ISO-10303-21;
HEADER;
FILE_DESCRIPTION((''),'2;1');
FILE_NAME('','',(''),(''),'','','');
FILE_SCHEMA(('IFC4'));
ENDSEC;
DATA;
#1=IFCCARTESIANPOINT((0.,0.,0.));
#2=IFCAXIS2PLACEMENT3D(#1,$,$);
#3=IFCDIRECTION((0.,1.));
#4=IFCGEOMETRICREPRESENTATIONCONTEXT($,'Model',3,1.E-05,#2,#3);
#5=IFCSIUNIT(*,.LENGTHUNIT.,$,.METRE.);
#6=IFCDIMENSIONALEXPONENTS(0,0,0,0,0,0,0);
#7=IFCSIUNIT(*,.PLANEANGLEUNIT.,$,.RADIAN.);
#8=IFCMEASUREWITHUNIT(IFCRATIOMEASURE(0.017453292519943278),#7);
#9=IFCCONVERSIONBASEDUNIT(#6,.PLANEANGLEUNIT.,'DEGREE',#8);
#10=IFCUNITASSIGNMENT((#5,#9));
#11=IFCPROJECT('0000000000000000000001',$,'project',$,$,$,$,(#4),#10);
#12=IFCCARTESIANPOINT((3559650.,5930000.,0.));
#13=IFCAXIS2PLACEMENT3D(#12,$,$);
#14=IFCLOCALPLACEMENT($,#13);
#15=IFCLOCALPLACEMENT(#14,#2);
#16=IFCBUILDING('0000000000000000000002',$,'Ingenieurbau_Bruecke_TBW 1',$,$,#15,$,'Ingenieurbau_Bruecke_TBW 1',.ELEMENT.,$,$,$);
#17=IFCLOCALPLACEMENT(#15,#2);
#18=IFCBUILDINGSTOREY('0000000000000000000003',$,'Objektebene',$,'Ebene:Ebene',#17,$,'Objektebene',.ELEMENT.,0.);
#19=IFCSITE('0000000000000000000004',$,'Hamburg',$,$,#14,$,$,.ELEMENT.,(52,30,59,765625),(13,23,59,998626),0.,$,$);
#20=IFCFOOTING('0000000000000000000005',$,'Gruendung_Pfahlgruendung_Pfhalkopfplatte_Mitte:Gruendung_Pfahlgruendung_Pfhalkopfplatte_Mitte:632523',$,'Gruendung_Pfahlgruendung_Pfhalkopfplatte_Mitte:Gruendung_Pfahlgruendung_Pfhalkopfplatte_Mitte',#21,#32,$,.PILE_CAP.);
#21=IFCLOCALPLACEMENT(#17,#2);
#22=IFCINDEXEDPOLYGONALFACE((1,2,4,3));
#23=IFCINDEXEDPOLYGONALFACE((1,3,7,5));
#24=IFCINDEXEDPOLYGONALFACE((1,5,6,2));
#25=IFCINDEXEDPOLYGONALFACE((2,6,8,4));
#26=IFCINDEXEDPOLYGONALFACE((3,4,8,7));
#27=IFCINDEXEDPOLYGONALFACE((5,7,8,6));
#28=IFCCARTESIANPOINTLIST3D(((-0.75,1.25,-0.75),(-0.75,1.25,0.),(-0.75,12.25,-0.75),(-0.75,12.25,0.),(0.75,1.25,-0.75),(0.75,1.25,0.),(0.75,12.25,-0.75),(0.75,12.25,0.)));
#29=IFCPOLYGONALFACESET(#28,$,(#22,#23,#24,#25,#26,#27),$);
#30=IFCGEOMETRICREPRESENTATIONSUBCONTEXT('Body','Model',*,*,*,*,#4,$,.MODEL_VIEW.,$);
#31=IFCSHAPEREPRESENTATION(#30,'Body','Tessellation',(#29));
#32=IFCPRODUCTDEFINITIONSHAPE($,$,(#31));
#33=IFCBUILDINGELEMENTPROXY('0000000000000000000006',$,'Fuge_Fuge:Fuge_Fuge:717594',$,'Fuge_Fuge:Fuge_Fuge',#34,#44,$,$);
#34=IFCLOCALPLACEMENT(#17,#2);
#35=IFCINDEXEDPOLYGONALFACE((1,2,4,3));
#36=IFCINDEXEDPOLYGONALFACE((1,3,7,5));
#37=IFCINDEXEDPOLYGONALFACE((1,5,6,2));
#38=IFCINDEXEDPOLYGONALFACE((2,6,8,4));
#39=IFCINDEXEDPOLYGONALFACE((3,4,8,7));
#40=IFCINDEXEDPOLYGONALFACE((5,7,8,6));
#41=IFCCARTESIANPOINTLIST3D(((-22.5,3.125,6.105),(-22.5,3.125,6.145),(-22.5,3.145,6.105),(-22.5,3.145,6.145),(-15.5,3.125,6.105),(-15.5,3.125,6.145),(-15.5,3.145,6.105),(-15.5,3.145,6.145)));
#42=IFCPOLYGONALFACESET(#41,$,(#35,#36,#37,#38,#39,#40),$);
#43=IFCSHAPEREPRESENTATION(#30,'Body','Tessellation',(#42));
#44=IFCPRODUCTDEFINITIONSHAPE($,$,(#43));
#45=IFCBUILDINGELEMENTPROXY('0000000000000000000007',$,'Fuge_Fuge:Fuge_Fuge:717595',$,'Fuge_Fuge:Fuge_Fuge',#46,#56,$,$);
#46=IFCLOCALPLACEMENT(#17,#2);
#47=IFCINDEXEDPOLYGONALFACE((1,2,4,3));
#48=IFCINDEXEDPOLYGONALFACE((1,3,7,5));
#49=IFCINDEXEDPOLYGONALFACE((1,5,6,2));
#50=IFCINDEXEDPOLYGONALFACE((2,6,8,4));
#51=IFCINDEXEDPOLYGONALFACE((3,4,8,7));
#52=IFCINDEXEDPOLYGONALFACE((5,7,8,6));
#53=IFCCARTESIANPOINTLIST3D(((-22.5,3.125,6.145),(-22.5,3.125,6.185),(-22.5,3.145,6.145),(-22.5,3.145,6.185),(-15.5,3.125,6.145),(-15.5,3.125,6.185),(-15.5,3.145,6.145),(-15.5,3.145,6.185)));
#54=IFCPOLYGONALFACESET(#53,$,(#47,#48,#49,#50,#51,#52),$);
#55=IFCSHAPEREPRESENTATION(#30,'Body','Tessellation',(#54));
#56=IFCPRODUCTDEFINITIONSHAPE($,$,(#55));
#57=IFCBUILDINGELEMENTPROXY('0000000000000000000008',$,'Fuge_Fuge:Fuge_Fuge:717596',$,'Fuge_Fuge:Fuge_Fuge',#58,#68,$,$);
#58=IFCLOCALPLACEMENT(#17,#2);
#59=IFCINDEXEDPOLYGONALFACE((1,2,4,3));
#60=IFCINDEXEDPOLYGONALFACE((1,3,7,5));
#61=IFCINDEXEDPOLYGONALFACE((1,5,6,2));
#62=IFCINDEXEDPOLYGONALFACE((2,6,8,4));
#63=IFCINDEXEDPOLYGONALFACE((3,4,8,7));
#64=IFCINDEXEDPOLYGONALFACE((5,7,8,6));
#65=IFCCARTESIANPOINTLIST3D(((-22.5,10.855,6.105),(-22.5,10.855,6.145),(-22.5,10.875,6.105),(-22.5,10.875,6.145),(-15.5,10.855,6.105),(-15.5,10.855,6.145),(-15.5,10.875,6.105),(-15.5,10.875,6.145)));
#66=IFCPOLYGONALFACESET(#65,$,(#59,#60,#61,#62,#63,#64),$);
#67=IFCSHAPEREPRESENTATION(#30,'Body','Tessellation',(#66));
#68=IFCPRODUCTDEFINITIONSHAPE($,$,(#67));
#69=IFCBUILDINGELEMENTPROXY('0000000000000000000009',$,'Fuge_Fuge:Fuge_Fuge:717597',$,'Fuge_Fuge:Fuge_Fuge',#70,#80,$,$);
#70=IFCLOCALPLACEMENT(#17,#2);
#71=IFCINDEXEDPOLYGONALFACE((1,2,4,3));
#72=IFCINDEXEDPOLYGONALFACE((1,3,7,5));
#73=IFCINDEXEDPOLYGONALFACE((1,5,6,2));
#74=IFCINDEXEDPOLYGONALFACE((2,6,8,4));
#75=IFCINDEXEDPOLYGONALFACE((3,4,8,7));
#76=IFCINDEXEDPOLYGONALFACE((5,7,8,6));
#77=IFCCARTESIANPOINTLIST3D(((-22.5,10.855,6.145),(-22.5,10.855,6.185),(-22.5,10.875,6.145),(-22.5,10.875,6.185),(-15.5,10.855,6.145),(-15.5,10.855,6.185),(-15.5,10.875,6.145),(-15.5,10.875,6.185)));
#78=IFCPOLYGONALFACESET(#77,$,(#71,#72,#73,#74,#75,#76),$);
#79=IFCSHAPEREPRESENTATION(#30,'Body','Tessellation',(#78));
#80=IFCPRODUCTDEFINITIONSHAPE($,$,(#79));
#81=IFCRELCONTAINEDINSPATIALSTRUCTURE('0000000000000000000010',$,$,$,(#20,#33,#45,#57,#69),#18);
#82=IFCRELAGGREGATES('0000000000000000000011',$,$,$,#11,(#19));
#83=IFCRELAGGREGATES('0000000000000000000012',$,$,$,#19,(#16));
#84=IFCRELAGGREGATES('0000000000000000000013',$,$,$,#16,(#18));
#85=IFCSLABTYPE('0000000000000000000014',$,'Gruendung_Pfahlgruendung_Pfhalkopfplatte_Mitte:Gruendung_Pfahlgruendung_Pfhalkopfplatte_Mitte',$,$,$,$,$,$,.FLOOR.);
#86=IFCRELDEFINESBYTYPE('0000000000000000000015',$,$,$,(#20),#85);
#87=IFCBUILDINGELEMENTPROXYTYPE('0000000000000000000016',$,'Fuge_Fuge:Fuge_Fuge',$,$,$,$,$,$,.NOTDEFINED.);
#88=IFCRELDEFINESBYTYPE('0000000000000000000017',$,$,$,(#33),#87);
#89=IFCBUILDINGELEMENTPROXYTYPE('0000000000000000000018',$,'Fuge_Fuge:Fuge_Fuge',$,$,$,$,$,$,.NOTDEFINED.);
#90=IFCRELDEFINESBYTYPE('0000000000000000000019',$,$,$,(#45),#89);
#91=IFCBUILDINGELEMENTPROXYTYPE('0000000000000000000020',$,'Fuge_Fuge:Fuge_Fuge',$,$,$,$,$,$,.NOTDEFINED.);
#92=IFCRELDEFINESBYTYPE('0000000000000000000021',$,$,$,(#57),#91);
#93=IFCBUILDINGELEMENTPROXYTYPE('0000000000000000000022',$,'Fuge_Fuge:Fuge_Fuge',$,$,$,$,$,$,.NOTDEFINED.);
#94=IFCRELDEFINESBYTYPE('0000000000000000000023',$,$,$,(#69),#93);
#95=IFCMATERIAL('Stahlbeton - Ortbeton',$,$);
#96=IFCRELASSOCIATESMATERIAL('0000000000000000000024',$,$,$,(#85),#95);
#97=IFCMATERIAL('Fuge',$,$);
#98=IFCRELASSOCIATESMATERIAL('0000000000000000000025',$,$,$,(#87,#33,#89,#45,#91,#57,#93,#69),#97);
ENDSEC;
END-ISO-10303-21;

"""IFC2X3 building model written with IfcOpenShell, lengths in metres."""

from ifc_helpers import new_model, entity, si_unit, converted_unit, direction, frame, frame_2d, origin, origin_2d_with_axis, place, context, subcontext, project, spatial, rectangle, extrude, source, transform, mapped, material, type_object, type_shapes, element, save


model = new_model("IFC2X3")

# Units and contexts
model_context = context("Model", 3, precision=1e-05, world=origin(), true_north=direction((0.0, 1.0)))
body_context = subcontext(model_context, "Body", "Model", "MODEL_VIEW")
ifc_project = project(units=[si_unit("LENGTHUNIT", "METRE"), converted_unit("PLANEANGLEUNIT", "DEGREE", entity("IfcRatioMeasure", 0.017453292519943278), si_unit("PLANEANGLEUNIT", "RADIAN"), dimensions=[0, 0, 0, 0, 0, 0, 0])], contexts=[model_context])

# Site, building, storey
site_placement = place(None, frame((3559650.0, 5930000.0, 0.0)))
site = spatial("IfcSite", under=ifc_project, at=site_placement, Name="Hamburg", CompositionType="ELEMENT", RefLatitude=(52, 30, 59, 765625), RefLongitude=(13, 23, 59, 998626), RefElevation=0.0)
building_placement = place(site_placement, origin())
building = spatial("IfcBuilding", under=site, at=building_placement, Name="Ingenieurbau_Bruecke_TBW 1", LongName="Ingenieurbau_Bruecke_TBW 1", CompositionType="ELEMENT")
storey_placement = place(building_placement, origin())
storey = spatial("IfcBuildingStorey", under=building, at=storey_placement, Name="Objektebene", ObjectType="Ebene:Ebene", LongName="Objektebene", CompositionType="ELEMENT", Elevation=0.0)

# Footing
ifc_material_1 = material(Name="Stahlbeton - Ortbeton")
slab_type_1 = type_object("IfcSlabType", Name="Gruendung_Pfahlgruendung_Pfhalkopfplatte_Mitte:Gruendung_Pfahlgruendung_Pfhalkopfplatte_Mitte", PredefinedType="FLOOR", material=ifc_material_1)
footing_1_placement = place(storey_placement, origin())
element("IfcFooting", 1, at=footing_1_placement, inside=storey, type_object=slab_type_1, Name="Gruendung_Pfahlgruendung_Pfhalkopfplatte_Mitte:Gruendung_Pfahlgruendung_Pfhalkopfplatte_Mitte:632523", ObjectType="Gruendung_Pfahlgruendung_Pfhalkopfplatte_Mitte:Gruendung_Pfahlgruendung_Pfhalkopfplatte_Mitte", PredefinedType="PILE_CAP", context=body_context, shape_type="SweptSolid", body=[
    extrude(rectangle(XDim=1.5, YDim=11.0, at=origin_2d_with_axis()), frame((0.0, 6.75, -0.75), z_axis=(0.0, 0.0, 1.0), x_axis=(-1.0, 0.0, 0.0)), (0.0, 0.0, 1.0), 0.75),
])

# Building element proxies
ifc_material_2 = material(Name="Fuge")
building_element_proxy_type_1 = type_object("IfcBuildingElementProxyType", Name="Fuge_Fuge:Fuge_Fuge", PredefinedType="NOTDEFINED", material=ifc_material_2)
shared_shape_1 = source(origin(), body_context, "Body", "SweptSolid", [
    extrude(rectangle(XDim=0.02, YDim=7.0, at=frame_2d((0.0, 0.0), x_axis=(1.0, 0.0))), frame((-19.0, 3.135, 6.105), z_axis=(0.0, 0.0, 1.0), x_axis=(0.0, -1.0, 0.0)), (0.0, 0.0, 1.0), 0.04),
])
type_shapes(building_element_proxy_type_1, [shared_shape_1])
proxy_1_placement = place(storey_placement, origin())
element("IfcBuildingElementProxy", 2, at=proxy_1_placement, inside=storey, type_object=building_element_proxy_type_1, material=ifc_material_2, Name="Fuge_Fuge:Fuge_Fuge:717594", ObjectType="Fuge_Fuge:Fuge_Fuge", context=body_context, shape_type="MappedRepresentation", body=[
    mapped(shared_shape_1, transform((0.0, 0.0, 0.0), scale=1.0)),
])
building_element_proxy_type_2 = type_object("IfcBuildingElementProxyType", Name="Fuge_Fuge:Fuge_Fuge", PredefinedType="NOTDEFINED", material=ifc_material_2)
shared_shape_2 = source(origin(), body_context, "Body", "SweptSolid", [
    extrude(rectangle(XDim=0.02, YDim=7.0, at=frame_2d((0.0, 0.0), x_axis=(1.0, 0.0))), frame((-19.0, 3.135, 6.145), z_axis=(0.0, 0.0, 1.0), x_axis=(0.0, -1.0, 0.0)), (0.0, 0.0, 1.0), 0.04),
])
type_shapes(building_element_proxy_type_2, [shared_shape_2])
proxy_2_placement = place(storey_placement, origin())
element("IfcBuildingElementProxy", 3, at=proxy_2_placement, inside=storey, type_object=building_element_proxy_type_2, material=ifc_material_2, Name="Fuge_Fuge:Fuge_Fuge:717595", ObjectType="Fuge_Fuge:Fuge_Fuge", context=body_context, shape_type="MappedRepresentation", body=[
    mapped(shared_shape_2, transform((0.0, 0.0, 0.0), scale=1.0)),
])
building_element_proxy_type_3 = type_object("IfcBuildingElementProxyType", Name="Fuge_Fuge:Fuge_Fuge", PredefinedType="NOTDEFINED", material=ifc_material_2)
shared_shape_3 = source(origin(), body_context, "Body", "SweptSolid", [
    extrude(rectangle(XDim=0.02, YDim=7.0, at=frame_2d((0.0, 0.0), x_axis=(1.0, 0.0))), frame((-19.0, 10.865, 6.105), z_axis=(0.0, 0.0, 1.0), x_axis=(0.0, -1.0, 0.0)), (0.0, 0.0, 1.0), 0.04),
])
type_shapes(building_element_proxy_type_3, [shared_shape_3])
proxy_3_placement = place(storey_placement, origin())
element("IfcBuildingElementProxy", 4, at=proxy_3_placement, inside=storey, type_object=building_element_proxy_type_3, material=ifc_material_2, Name="Fuge_Fuge:Fuge_Fuge:717596", ObjectType="Fuge_Fuge:Fuge_Fuge", context=body_context, shape_type="MappedRepresentation", body=[
    mapped(shared_shape_3, transform((0.0, 0.0, 0.0), scale=1.0)),
])
building_element_proxy_type_4 = type_object("IfcBuildingElementProxyType", Name="Fuge_Fuge:Fuge_Fuge", PredefinedType="NOTDEFINED", material=ifc_material_2)
shared_shape_4 = source(origin(), body_context, "Body", "SweptSolid", [
    extrude(rectangle(XDim=0.02, YDim=7.0, at=frame_2d((0.0, 0.0), x_axis=(1.0, 0.0))), frame((-19.0, 10.865, 6.145), z_axis=(0.0, 0.0, 1.0), x_axis=(0.0, -1.0, 0.0)), (0.0, 0.0, 1.0), 0.04),
])
type_shapes(building_element_proxy_type_4, [shared_shape_4])
proxy_4_placement = place(storey_placement, origin())
element("IfcBuildingElementProxy", 5, at=proxy_4_placement, inside=storey, type_object=building_element_proxy_type_4, material=ifc_material_2, Name="Fuge_Fuge:Fuge_Fuge:717597", ObjectType="Fuge_Fuge:Fuge_Fuge", context=body_context, shape_type="MappedRepresentation", body=[
    mapped(shared_shape_4, transform((0.0, 0.0, 0.0), scale=1.0)),
])

save(model, "model.ifc")
